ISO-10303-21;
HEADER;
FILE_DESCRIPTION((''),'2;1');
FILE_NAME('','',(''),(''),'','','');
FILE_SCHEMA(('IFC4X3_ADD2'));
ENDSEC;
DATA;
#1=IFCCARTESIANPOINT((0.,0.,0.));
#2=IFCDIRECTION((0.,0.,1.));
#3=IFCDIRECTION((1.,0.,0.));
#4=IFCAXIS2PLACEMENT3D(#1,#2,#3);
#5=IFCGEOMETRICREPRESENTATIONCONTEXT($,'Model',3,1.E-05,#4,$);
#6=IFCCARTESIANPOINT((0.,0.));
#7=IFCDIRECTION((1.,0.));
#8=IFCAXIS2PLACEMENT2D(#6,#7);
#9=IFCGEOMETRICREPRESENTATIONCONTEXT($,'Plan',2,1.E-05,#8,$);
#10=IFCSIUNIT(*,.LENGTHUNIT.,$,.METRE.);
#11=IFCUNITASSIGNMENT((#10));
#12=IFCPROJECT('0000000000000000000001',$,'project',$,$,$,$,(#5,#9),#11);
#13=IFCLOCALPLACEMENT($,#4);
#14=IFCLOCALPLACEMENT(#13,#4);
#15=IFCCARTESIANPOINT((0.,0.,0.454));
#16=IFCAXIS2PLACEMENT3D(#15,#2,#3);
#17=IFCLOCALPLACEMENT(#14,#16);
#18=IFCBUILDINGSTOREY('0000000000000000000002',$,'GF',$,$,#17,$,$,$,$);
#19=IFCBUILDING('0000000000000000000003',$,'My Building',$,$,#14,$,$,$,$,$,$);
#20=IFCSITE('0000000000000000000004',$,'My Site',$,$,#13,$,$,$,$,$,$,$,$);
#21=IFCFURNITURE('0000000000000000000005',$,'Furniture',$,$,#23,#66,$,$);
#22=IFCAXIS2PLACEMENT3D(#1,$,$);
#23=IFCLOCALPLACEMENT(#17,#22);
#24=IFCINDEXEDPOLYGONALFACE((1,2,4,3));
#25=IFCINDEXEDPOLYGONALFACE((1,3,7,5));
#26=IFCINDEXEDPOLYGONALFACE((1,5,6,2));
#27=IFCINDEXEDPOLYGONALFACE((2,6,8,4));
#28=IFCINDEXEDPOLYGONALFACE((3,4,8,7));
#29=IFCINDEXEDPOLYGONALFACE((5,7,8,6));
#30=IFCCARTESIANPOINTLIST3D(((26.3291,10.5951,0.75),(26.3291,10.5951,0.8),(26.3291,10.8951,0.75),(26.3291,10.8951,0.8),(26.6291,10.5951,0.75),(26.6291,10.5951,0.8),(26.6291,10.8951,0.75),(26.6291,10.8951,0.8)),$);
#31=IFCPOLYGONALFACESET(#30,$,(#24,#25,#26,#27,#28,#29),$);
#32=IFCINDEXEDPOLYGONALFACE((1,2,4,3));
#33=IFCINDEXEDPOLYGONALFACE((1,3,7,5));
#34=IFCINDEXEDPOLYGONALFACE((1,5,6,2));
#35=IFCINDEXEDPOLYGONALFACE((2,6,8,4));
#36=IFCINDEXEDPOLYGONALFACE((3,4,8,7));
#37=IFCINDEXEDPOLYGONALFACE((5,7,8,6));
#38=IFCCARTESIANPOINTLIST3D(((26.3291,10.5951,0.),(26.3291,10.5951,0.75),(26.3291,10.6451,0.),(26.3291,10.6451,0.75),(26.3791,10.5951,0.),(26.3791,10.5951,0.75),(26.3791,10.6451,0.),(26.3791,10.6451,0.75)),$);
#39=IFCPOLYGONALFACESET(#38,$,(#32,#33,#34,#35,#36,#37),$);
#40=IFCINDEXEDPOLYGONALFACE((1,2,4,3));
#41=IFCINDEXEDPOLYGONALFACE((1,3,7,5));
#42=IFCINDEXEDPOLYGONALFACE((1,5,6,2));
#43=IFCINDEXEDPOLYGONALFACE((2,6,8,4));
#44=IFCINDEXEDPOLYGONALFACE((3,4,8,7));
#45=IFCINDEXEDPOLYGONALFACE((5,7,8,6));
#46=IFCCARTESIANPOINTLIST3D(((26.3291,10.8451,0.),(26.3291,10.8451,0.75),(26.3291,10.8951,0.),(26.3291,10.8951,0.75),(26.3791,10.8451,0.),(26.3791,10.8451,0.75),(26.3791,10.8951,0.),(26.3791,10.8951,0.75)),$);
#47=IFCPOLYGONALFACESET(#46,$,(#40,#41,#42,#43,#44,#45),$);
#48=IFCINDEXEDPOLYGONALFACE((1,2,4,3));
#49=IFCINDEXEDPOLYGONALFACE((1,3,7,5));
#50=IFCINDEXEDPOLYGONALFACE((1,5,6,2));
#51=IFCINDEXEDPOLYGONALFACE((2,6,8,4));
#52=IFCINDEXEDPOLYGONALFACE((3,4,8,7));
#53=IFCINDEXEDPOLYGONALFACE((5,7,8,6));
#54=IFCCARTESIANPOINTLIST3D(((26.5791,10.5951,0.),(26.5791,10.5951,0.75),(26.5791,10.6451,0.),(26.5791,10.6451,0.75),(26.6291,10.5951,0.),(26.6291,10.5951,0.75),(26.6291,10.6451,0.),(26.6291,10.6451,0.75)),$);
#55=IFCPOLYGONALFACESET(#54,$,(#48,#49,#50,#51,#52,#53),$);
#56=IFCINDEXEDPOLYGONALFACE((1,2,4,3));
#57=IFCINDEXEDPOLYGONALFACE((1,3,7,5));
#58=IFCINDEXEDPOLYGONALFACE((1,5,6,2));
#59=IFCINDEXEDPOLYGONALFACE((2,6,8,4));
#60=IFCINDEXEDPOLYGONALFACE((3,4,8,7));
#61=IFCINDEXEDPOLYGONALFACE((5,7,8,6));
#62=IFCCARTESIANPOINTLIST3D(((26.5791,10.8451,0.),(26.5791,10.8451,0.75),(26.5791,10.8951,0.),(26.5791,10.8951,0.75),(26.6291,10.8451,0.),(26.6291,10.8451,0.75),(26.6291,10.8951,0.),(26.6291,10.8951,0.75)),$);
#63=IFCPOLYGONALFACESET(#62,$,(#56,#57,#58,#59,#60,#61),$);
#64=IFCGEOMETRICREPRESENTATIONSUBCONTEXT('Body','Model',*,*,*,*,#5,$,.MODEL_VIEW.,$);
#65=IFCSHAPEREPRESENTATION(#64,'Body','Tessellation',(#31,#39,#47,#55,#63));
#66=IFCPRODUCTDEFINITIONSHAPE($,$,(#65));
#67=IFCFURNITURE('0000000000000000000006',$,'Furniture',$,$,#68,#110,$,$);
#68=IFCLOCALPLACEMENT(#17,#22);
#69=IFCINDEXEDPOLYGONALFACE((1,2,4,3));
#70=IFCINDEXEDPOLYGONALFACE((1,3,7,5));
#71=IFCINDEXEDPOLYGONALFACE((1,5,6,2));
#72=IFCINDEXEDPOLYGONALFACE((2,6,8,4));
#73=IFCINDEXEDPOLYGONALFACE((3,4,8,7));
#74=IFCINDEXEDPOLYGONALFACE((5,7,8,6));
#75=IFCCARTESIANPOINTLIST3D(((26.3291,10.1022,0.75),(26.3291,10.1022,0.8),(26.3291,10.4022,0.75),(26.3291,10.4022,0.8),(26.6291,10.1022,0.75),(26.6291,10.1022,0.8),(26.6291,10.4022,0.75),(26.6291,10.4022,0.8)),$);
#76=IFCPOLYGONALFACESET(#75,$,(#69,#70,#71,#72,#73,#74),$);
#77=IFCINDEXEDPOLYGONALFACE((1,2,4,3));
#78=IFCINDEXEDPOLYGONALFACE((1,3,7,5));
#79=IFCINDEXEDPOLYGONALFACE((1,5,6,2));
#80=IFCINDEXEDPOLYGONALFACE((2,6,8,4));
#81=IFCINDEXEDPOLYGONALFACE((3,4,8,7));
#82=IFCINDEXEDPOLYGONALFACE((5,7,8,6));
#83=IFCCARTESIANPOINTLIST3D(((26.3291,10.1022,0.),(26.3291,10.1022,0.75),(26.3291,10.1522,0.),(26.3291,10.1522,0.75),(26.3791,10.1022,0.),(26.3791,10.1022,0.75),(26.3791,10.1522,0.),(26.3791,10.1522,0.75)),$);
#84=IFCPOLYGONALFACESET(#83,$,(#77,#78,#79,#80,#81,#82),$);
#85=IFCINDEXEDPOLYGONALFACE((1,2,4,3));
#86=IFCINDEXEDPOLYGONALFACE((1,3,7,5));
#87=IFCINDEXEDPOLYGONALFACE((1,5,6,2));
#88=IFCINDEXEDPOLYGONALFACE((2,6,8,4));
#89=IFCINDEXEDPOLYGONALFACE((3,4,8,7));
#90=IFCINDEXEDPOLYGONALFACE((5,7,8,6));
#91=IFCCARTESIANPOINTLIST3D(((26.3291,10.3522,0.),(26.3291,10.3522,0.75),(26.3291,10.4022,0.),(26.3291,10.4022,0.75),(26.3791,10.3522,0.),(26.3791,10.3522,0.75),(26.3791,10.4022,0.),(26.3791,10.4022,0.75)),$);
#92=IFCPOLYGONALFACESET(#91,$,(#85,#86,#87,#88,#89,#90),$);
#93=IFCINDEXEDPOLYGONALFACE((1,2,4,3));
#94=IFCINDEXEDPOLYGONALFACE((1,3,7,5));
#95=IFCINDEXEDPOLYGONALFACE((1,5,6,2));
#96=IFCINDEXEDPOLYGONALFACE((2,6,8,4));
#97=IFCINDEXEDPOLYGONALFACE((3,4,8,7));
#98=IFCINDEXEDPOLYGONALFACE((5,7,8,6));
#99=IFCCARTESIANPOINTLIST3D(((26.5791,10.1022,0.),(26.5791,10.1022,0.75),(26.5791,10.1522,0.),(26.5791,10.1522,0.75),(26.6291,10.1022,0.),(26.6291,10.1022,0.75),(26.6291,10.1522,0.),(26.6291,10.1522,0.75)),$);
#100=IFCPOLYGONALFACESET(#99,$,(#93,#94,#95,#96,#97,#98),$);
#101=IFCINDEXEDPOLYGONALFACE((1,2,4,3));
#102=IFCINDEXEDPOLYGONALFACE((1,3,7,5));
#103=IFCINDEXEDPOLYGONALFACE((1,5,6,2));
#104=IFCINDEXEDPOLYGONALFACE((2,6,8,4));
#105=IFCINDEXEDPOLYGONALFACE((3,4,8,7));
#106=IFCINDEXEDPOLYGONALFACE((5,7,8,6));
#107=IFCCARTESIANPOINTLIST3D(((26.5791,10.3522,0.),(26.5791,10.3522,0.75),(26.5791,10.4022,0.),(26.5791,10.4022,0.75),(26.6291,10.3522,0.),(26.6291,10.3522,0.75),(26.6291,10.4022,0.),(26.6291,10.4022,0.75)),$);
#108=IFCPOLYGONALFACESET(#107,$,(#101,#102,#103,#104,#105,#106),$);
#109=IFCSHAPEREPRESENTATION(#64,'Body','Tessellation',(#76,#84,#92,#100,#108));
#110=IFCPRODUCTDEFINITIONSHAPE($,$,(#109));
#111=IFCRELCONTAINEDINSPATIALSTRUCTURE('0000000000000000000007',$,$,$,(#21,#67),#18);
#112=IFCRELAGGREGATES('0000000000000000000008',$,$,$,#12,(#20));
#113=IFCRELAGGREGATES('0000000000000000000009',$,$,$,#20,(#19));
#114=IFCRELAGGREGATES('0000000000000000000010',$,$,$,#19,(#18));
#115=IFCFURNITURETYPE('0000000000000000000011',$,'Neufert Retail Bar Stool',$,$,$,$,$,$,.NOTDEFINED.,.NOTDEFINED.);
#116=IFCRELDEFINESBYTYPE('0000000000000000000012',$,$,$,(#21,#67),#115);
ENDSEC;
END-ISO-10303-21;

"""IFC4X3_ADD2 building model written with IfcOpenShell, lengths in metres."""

from ifc_helpers import new_model, entity, si_unit, frame, origin_with_axes, origin_2d_with_axis, place, context, subcontext, project, spatial, line, indexed_curve, outline, extrude, shape, source, transform, mapped, type_object, type_shapes, element, save


model = new_model("IFC4X3_ADD2")

# Units and contexts
model_context = context("Model", 3, precision=1e-05, world=origin_with_axes())
plan_context = context("Plan", 2, precision=1e-05, world=origin_2d_with_axis())
body_context_1 = subcontext(model_context, "Body", "Model", "MODEL_VIEW")
body_context_2 = subcontext(plan_context, "Body", "Plan", "PLAN_VIEW")
ifc_project = project(units=[si_unit("LENGTHUNIT", "METRE")], contexts=[model_context, plan_context])

# Site, building, storey
site_placement = place(None, origin_with_axes())
site = spatial("IfcSite", under=ifc_project, at=site_placement, Name="My Site")
building_placement = place(site_placement, origin_with_axes())
building = spatial("IfcBuilding", under=site, at=building_placement, Name="My Building")
storey_placement = place(building_placement, frame((0.0, 0.0, 0.454), z_axis=(0.0, 0.0, 1.0), x_axis=(1.0, 0.0, 0.0)))
storey = spatial("IfcBuildingStorey", under=building, at=storey_placement, Name="GF")

# Furniture
furniture_type = type_object("IfcFurnitureType", Name="Neufert Retail Bar Stool", AssemblyPlace="NOTDEFINED", PredefinedType="NOTDEFINED")
shared_shape_1 = source(origin_with_axes(), body_context_1, "Body", "SweptSolid", [
    extrude(outline(indexed_curve([(0.15, 0.0), (-0.15, 0.0), (-0.15, -0.3), (0.15, -0.3)], segments=[line(3, 2), line(2, 1), line(1, 4), line(4, 3)], self_intersect=False)), frame((0.0, 0.0, 0.8), z_axis=(0.0, 0.0, 1.0), x_axis=(1.0, 0.0, 0.0)), (0.0, 0.0, -1.0), 0.05),
    extrude(outline(indexed_curve([(-0.15, 0.0), (-0.1, 0.0), (-0.1, -0.05), (-0.15, -0.05)], segments=[line(1, 2, 3, 4, 1)])), origin_with_axes(), (0.0, 0.0, 1.0), 0.75),
    extrude(outline(indexed_curve([(0.15, 0.0), (0.1, 0.0), (0.1, -0.05), (0.15, -0.05)], segments=[line(1, 2, 3, 4, 1)])), origin_with_axes(), (0.0, 0.0, 1.0), 0.75),
    extrude(outline(indexed_curve([(-0.15, -0.3), (-0.1, -0.3), (-0.1, -0.25), (-0.15, -0.25)], segments=[line(1, 2, 3, 4, 1)])), origin_with_axes(), (0.0, 0.0, 1.0), 0.75),
    extrude(outline(indexed_curve([(0.15, -0.3), (0.1, -0.3), (0.1, -0.25), (0.15, -0.25)], segments=[line(1, 2, 3, 4, 1)])), origin_with_axes(), (0.0, 0.0, 1.0), 0.75),
])
shared_shape_2 = source(origin_with_axes(), body_context_2, "Body", "Curve2D", [
    entity("IfcIndexedPolyCurve", entity("IfcCartesianPointList2D", [[-0.15, -0.3], [0.15, -0.3]])),
    entity("IfcIndexedPolyCurve", entity("IfcCartesianPointList2D", [[-0.15, -0.3], [-0.15, -0.15], [-0.1061, -0.0439], [0.0, 0.0], [0.1061, -0.0439], [0.15, -0.15], [0.15, -0.3]]), [entity("IfcLineIndex", [1, 2]), entity("IfcArcIndex", [2, 3, 4]), entity("IfcArcIndex", [4, 5, 6]), entity("IfcLineIndex", [6, 7])]),
    entity("IfcIndexedPolyCurve", entity("IfcCartesianPointList2D", [[-0.12, -0.3], [-0.12, -0.15], [-0.0849, -0.0651], [0.0, -0.03], [0.0849, -0.0651], [0.12, -0.15], [0.12, -0.3]]), [entity("IfcLineIndex", [1, 2]), entity("IfcArcIndex", [2, 3, 4]), entity("IfcArcIndex", [4, 5, 6]), entity("IfcLineIndex", [6, 7])]),
])
type_shapes(furniture_type, [shared_shape_1, shared_shape_2])
for number, where, z_axis, x_axis, name in (
    (1, (26.3291, 10.7451, 0.0), (0.0, 0.0, 1.0), (0.0, 1.0, 0.0), "Furniture"),
    (2, (26.3291, 10.2522, 0.0), (0.0, 0.0, 1.0), (0.0, 1.0, 0.0), "Furniture"),
):
    element("IfcFurniture", number, at=place(storey_placement, frame(where, z_axis=z_axis, x_axis=x_axis)), inside=storey, type_object=furniture_type, Name=name, shapes=[
        shape(body_context_1, "Body", "MappedRepresentation", [mapped(shared_shape_1, transform((0.0, 0.0, 0.0), x_axis=(1.0, 0.0, 0.0), y_axis=(0.0, 1.0, 0.0), z_axis=(0.0, 0.0, 1.0), scale=1.0))]),
        shape(body_context_2, "Body", "MappedRepresentation", [mapped(shared_shape_2, transform((0.0, 0.0, 0.0), x_axis=(1.0, 0.0, 0.0), y_axis=(0.0, 1.0, 0.0), z_axis=(0.0, 0.0, 1.0), scale=1.0))]),
    ])

save(model, "model.ifc")
